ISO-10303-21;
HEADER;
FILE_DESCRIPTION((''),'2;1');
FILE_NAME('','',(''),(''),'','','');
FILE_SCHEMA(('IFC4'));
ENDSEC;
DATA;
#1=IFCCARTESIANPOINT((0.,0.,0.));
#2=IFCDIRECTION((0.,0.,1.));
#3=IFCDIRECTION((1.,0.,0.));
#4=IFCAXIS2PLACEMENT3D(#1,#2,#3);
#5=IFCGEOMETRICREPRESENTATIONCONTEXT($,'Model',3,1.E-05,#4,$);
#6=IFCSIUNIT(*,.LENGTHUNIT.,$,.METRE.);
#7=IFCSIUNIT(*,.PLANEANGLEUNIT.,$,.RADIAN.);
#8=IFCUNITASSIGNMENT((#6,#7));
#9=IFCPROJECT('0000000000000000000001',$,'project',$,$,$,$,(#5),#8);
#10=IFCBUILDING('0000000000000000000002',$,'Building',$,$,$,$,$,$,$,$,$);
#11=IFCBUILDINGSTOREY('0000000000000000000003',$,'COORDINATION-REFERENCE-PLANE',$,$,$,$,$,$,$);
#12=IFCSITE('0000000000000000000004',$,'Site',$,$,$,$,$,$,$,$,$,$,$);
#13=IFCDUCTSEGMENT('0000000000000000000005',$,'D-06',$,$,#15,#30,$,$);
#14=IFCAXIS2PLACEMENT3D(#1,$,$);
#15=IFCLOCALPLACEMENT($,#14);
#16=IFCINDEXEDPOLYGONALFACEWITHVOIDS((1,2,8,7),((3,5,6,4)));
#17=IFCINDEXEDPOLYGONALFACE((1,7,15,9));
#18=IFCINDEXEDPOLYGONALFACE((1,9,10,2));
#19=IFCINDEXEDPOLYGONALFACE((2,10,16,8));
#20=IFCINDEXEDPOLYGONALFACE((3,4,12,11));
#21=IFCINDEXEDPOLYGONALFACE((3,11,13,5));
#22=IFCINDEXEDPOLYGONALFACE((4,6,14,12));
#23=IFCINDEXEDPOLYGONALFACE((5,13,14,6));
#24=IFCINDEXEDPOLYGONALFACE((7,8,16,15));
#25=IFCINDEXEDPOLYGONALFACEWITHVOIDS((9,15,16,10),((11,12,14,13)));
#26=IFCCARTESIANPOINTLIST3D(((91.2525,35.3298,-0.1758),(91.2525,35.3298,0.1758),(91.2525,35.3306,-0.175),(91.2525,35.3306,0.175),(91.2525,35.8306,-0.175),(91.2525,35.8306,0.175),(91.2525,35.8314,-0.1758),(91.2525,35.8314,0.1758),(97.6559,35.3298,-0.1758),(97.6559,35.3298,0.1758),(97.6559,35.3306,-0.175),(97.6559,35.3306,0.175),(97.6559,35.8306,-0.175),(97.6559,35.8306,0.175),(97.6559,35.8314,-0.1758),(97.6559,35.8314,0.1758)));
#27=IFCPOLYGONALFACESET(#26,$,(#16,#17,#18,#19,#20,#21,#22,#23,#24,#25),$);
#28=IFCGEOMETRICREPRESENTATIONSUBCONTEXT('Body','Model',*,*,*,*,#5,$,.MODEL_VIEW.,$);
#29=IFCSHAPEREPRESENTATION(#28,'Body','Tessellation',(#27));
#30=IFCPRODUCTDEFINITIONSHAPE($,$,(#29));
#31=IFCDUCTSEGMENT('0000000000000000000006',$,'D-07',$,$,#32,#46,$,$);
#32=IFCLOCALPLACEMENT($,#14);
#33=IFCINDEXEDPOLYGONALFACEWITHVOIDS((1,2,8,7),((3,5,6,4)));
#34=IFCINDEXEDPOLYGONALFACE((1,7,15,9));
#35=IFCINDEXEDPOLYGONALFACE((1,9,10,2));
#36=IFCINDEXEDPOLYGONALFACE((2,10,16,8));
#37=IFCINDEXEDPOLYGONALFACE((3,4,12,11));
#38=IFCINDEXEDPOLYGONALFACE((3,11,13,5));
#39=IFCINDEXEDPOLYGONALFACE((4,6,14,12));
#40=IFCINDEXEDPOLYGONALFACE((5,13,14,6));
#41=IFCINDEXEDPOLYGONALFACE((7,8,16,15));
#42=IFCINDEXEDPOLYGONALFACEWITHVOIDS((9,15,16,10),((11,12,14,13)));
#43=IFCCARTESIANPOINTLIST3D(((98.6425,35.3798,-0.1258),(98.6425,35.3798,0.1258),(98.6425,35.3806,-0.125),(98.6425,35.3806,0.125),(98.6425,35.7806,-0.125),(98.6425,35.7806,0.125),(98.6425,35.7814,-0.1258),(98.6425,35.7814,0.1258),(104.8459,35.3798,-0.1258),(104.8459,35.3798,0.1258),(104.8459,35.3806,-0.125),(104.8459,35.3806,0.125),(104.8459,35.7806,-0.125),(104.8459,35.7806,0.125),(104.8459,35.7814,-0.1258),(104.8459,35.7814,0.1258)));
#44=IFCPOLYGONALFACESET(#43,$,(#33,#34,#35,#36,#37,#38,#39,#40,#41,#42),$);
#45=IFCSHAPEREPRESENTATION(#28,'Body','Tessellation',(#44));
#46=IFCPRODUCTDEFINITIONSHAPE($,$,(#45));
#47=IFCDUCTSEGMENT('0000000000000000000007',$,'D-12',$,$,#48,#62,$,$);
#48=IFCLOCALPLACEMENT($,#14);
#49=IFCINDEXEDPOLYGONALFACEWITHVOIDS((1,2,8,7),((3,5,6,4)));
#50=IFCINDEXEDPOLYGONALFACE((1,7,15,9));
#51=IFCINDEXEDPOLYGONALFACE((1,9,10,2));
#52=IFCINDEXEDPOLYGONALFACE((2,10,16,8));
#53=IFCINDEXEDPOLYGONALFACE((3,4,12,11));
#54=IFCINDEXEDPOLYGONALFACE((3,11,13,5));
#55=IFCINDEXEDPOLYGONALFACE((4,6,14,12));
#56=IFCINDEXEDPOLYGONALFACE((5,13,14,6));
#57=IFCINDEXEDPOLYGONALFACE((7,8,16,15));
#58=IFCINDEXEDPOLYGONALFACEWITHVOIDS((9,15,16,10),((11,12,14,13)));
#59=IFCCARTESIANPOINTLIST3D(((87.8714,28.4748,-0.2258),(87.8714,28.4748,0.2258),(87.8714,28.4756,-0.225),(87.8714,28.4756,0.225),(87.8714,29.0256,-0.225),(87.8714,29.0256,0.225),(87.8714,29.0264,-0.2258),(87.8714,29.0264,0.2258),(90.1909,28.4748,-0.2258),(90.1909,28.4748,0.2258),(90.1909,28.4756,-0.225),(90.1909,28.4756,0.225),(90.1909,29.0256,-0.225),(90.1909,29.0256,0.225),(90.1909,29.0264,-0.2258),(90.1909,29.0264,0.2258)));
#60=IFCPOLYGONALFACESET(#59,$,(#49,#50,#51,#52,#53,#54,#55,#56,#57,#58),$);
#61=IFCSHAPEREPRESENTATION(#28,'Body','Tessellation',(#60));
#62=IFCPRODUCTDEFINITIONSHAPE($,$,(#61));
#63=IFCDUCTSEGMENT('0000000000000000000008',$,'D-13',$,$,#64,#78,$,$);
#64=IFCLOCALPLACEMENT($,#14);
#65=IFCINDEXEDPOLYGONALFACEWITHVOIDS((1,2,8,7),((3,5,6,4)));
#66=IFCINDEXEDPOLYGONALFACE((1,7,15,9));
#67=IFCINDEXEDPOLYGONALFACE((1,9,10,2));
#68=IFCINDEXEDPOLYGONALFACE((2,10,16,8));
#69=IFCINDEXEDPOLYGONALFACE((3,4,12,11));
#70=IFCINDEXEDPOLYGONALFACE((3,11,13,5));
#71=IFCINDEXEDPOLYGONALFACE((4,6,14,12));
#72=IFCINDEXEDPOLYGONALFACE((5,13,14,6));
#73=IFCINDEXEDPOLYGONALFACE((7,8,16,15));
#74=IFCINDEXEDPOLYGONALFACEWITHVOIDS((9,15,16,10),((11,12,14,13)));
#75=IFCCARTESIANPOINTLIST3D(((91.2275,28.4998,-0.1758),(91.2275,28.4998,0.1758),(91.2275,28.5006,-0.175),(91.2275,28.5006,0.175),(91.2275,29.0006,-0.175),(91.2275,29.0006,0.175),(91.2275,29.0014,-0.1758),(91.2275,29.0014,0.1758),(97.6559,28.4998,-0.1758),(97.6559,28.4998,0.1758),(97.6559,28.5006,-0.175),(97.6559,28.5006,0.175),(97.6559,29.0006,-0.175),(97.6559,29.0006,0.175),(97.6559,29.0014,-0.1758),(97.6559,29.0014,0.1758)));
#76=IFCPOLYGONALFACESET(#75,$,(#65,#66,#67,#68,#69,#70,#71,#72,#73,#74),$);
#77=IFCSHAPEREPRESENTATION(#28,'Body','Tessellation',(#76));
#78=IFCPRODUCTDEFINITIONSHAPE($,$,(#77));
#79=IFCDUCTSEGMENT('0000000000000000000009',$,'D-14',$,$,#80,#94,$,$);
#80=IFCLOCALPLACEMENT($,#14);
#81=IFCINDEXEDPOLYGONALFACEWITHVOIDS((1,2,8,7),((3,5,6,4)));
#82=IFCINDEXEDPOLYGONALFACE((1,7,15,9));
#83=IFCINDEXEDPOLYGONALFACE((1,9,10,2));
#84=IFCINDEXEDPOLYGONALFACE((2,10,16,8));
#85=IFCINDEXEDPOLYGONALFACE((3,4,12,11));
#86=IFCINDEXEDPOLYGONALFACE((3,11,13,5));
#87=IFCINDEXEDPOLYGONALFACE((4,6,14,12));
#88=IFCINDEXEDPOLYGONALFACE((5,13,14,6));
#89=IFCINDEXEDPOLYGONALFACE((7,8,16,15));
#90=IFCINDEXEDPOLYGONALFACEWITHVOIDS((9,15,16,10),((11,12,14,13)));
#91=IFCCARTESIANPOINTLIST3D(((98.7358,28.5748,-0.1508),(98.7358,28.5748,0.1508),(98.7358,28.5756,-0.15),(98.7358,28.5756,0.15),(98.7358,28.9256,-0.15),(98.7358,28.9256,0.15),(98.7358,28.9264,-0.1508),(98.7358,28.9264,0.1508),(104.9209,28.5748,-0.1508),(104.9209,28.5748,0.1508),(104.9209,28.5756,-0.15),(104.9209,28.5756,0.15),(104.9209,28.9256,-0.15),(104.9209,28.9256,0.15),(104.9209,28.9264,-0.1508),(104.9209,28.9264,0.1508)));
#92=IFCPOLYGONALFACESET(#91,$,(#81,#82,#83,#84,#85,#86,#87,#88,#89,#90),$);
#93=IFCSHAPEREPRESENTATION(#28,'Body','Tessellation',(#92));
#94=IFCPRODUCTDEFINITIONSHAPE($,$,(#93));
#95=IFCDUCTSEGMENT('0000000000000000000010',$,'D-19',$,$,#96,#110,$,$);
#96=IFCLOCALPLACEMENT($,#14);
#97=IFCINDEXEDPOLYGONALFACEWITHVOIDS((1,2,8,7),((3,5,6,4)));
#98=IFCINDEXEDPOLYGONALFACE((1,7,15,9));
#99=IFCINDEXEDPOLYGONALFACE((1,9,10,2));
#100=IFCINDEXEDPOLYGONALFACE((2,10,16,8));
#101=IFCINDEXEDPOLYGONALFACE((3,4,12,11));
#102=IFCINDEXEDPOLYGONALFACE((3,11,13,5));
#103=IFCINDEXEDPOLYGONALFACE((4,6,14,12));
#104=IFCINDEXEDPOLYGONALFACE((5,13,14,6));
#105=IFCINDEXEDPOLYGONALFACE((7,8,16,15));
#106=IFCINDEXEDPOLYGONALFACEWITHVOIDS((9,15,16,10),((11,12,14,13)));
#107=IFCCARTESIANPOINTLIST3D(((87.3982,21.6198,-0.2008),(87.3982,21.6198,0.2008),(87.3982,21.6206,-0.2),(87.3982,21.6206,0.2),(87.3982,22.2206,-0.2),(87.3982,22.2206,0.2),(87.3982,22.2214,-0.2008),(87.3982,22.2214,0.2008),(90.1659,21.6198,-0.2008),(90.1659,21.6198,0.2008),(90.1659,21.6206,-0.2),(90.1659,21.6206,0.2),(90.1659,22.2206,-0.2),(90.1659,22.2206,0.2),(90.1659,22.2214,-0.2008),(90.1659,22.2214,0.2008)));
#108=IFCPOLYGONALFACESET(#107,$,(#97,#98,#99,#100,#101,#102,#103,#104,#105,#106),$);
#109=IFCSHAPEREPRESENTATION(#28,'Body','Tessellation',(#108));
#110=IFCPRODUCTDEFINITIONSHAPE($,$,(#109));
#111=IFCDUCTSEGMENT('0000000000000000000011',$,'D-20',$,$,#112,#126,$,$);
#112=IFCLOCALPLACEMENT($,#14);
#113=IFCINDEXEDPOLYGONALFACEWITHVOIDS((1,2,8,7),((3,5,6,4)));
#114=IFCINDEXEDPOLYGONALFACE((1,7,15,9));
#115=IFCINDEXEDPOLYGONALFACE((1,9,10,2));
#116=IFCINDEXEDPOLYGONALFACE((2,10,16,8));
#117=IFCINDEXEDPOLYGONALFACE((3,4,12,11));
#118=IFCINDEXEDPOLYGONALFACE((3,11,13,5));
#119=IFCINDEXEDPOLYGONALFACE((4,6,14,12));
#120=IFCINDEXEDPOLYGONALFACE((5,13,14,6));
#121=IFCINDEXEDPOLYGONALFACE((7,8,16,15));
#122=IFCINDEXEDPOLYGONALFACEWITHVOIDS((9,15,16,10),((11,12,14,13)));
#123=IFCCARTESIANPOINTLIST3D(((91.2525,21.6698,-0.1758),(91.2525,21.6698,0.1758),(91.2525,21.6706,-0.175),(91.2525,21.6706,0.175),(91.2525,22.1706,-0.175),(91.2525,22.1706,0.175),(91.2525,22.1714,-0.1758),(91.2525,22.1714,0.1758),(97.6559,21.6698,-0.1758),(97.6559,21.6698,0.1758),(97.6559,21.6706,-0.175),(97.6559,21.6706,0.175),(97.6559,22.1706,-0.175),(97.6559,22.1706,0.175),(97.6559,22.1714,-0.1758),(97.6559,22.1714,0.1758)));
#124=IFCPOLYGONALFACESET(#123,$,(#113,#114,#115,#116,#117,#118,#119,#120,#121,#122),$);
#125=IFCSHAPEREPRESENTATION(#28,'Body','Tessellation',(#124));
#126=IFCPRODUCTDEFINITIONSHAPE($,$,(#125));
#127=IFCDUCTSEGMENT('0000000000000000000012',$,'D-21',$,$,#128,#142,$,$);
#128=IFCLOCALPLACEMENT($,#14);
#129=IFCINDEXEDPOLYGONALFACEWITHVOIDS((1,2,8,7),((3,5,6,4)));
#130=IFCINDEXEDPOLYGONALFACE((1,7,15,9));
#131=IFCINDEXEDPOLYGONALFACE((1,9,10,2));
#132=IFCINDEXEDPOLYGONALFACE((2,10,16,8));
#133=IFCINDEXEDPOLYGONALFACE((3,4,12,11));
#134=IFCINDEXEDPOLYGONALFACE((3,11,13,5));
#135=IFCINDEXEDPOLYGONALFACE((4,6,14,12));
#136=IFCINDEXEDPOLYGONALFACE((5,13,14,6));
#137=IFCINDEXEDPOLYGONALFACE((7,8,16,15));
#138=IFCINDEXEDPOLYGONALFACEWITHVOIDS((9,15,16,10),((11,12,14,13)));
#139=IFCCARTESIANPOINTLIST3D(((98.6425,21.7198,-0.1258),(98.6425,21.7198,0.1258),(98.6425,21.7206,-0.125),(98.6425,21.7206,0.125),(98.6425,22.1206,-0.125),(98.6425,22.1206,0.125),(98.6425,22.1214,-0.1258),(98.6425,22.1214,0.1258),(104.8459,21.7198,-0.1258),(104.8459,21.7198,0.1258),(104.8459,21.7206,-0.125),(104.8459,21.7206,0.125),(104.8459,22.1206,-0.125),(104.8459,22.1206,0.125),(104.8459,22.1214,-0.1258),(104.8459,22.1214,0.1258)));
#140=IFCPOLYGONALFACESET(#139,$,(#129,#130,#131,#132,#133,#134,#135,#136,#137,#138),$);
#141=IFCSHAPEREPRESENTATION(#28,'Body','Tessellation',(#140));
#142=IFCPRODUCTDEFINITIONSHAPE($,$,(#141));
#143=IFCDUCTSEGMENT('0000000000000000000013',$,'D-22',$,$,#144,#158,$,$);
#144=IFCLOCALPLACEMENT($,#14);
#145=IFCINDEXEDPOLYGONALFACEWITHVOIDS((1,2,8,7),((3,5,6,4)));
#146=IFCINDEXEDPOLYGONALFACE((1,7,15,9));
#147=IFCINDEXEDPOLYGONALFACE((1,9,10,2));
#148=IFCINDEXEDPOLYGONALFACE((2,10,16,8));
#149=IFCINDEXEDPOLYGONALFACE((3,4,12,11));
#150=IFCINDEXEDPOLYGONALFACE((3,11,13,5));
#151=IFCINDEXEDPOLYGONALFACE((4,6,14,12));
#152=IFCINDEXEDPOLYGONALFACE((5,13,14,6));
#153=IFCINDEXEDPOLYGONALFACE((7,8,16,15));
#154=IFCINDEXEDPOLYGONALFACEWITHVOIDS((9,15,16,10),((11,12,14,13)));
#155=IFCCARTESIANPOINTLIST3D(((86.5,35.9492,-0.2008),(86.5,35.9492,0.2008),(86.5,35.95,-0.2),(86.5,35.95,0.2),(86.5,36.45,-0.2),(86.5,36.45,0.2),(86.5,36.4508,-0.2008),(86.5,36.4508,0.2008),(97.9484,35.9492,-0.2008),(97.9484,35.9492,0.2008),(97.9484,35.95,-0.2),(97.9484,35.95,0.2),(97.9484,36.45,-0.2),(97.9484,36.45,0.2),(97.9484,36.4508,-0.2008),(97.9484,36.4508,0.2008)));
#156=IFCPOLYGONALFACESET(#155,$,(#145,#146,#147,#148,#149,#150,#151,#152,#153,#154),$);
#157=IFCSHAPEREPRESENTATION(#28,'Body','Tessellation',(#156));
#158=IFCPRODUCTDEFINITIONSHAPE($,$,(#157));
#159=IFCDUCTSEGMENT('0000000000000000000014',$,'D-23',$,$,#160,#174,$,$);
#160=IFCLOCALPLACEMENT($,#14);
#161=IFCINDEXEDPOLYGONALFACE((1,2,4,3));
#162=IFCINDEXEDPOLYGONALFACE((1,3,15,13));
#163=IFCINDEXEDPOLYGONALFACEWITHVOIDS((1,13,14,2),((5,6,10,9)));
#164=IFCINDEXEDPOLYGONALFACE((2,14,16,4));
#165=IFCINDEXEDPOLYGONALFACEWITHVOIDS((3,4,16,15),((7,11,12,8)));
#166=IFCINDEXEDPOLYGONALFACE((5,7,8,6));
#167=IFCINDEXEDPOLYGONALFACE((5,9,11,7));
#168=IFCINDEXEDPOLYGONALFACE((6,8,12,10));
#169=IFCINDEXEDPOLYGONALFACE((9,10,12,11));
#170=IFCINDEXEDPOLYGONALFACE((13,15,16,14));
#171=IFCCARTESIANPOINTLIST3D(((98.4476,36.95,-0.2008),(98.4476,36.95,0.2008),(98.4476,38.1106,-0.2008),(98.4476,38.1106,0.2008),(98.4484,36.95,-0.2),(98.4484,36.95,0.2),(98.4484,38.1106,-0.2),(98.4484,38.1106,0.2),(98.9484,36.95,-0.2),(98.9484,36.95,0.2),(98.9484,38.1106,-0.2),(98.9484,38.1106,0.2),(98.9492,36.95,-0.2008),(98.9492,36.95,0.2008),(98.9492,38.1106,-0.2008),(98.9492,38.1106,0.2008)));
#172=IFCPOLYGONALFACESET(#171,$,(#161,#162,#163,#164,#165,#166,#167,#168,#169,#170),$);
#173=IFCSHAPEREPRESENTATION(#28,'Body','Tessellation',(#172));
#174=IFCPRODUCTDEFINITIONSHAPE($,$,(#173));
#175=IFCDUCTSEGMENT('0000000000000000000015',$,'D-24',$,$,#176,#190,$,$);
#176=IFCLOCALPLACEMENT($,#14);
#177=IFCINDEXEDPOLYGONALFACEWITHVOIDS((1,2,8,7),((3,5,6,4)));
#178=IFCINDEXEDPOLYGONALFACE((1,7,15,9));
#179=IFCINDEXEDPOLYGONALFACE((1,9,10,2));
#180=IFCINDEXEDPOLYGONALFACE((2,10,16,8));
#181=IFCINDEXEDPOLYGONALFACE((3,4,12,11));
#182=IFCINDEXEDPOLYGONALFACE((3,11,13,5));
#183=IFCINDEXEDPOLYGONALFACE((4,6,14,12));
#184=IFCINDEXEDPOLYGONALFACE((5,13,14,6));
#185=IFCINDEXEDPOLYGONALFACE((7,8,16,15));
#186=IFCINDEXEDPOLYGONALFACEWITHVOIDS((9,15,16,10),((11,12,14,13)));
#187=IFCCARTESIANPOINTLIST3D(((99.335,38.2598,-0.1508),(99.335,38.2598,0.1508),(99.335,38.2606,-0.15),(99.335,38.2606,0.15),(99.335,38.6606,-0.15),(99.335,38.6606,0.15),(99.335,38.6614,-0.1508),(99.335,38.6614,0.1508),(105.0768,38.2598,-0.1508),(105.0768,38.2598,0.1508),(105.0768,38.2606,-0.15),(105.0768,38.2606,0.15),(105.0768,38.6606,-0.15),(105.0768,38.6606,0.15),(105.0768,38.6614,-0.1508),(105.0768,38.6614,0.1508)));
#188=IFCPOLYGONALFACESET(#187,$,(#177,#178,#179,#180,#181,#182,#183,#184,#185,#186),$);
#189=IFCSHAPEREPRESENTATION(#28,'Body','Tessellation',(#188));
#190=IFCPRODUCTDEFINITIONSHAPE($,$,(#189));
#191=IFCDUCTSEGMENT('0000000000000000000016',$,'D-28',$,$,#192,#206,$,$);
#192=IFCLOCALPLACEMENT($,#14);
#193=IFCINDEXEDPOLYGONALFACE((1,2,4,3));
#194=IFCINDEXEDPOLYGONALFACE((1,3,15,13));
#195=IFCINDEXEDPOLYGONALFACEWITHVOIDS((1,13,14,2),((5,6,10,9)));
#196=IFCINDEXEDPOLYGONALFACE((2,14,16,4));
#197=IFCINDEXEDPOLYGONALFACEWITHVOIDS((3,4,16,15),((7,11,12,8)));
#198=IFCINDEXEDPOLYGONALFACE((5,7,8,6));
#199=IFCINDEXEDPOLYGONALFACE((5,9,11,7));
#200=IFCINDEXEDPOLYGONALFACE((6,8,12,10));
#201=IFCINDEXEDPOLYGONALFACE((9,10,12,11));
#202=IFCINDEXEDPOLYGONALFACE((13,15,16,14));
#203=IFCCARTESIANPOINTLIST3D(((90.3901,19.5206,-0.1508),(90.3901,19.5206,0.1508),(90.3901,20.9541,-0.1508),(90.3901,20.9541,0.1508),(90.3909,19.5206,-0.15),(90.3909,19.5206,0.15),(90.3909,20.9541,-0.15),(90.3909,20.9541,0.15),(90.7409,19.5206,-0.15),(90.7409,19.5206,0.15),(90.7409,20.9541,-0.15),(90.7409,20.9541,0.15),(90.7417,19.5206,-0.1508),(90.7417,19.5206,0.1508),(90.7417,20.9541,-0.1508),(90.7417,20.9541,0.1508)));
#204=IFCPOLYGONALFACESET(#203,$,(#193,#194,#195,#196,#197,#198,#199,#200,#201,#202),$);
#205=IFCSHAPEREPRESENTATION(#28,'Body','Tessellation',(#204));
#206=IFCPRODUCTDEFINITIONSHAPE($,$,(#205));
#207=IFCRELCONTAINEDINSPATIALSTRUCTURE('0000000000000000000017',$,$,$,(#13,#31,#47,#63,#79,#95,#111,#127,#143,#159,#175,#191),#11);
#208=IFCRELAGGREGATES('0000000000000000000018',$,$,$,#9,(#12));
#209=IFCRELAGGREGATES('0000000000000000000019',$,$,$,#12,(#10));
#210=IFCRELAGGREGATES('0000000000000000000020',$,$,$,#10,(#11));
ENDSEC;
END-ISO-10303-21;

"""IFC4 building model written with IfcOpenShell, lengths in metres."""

from ifc_helpers import new_model, si_unit, frame, origin, origin_with_axes, place, context, subcontext, project, spatial, hollow_rectangle, extrude, element, save


model = new_model("IFC4")

# Units and contexts
model_context = context("Model", 3, precision=1e-05, world=origin_with_axes())
body_context = subcontext(model_context, "Body", "Model", "MODEL_VIEW")
ifc_project = project(units=[si_unit("LENGTHUNIT", "METRE"), si_unit("PLANEANGLEUNIT", "RADIAN")], contexts=[model_context])

# Site, building, storey
site = spatial("IfcSite", under=ifc_project, Name="Site")
building = spatial("IfcBuilding", under=site, Name="Building")
storey = spatial("IfcBuildingStorey", under=building, Name="COORDINATION-REFERENCE-PLANE")

# Duct segments
duct_segment_1_placement = place(None, frame((91.2525, 35.5806, 0.0), z_axis=(1.0, 0.0, 0.0), x_axis=(0.0, 1.0, 0.0)))
element("IfcDuctSegment", 1, at=duct_segment_1_placement, inside=storey, Name="D-06", context=body_context, shape_type="SweptSolid", body=[
    extrude(hollow_rectangle(XDim=0.5016, YDim=0.3516, WallThickness=0.0008), origin(), (0.0, 0.0, 1.0), 6.4034),
])
duct_segment_2_placement = place(None, frame((98.6425, 35.5806, 0.0), z_axis=(1.0, 0.0, 0.0), x_axis=(0.0, 1.0, 0.0)))
element("IfcDuctSegment", 2, at=duct_segment_2_placement, inside=storey, Name="D-07", context=body_context, shape_type="SweptSolid", body=[
    extrude(hollow_rectangle(XDim=0.4016, YDim=0.2516, WallThickness=0.0008), origin(), (0.0, 0.0, 1.0), 6.2034),
])
duct_segment_3_placement = place(None, frame((87.8714, 28.7506, 0.0), z_axis=(1.0, 0.0, 0.0), x_axis=(0.0, 1.0, 0.0)))
element("IfcDuctSegment", 3, at=duct_segment_3_placement, inside=storey, Name="D-12", context=body_context, shape_type="SweptSolid", body=[
    extrude(hollow_rectangle(XDim=0.5516, YDim=0.4516, WallThickness=0.0008), origin(), (0.0, 0.0, 1.0), 2.3195),
])
duct_segment_4_placement = place(None, frame((91.2275, 28.7506, 0.0), z_axis=(1.0, 0.0, 0.0), x_axis=(0.0, 1.0, 0.0)))
element("IfcDuctSegment", 4, at=duct_segment_4_placement, inside=storey, Name="D-13", context=body_context, shape_type="SweptSolid", body=[
    extrude(hollow_rectangle(XDim=0.5016, YDim=0.3516, WallThickness=0.0008), origin(), (0.0, 0.0, 1.0), 6.4284),
])
duct_segment_5_placement = place(None, frame((98.7358, 28.7506, 0.0), z_axis=(1.0, 0.0, 0.0), x_axis=(0.0, 1.0, 0.0)))
element("IfcDuctSegment", 5, at=duct_segment_5_placement, inside=storey, Name="D-14", context=body_context, shape_type="SweptSolid", body=[
    extrude(hollow_rectangle(XDim=0.3516, YDim=0.3016, WallThickness=0.0008), origin(), (0.0, 0.0, 1.0), 6.1851),
])
duct_segment_6_placement = place(None, frame((87.3982, 21.9206, 0.0), z_axis=(1.0, 0.0, 0.0), x_axis=(0.0, 1.0, 0.0)))
element("IfcDuctSegment", 6, at=duct_segment_6_placement, inside=storey, Name="D-19", context=body_context, shape_type="SweptSolid", body=[
    extrude(hollow_rectangle(XDim=0.6016, YDim=0.4016, WallThickness=0.0008), origin(), (0.0, 0.0, 1.0), 2.7677),
])
duct_segment_7_placement = place(None, frame((91.2525, 21.9206, 0.0), z_axis=(1.0, 0.0, 0.0), x_axis=(0.0, 1.0, 0.0)))
element("IfcDuctSegment", 7, at=duct_segment_7_placement, inside=storey, Name="D-20", context=body_context, shape_type="SweptSolid", body=[
    extrude(hollow_rectangle(XDim=0.5016, YDim=0.3516, WallThickness=0.0008), origin(), (0.0, 0.0, 1.0), 6.4034),
])
duct_segment_8_placement = place(None, frame((98.6425, 21.9206, 0.0), z_axis=(1.0, 0.0, 0.0), x_axis=(0.0, 1.0, 0.0)))
element("IfcDuctSegment", 8, at=duct_segment_8_placement, inside=storey, Name="D-21", context=body_context, shape_type="SweptSolid", body=[
    extrude(hollow_rectangle(XDim=0.4016, YDim=0.2516, WallThickness=0.0008), origin(), (0.0, 0.0, 1.0), 6.2034),
])
duct_segment_9_placement = place(None, frame((86.5, 36.2, 0.0), z_axis=(1.0, 0.0, 0.0), x_axis=(0.0, 1.0, 0.0)))
element("IfcDuctSegment", 9, at=duct_segment_9_placement, inside=storey, Name="D-22", context=body_context, shape_type="SweptSolid", body=[
    extrude(hollow_rectangle(XDim=0.5016, YDim=0.4016, WallThickness=0.0008), origin(), (0.0, 0.0, 1.0), 11.4484),
])
duct_segment_10_placement = place(None, frame((98.6984, 36.95, 0.0), z_axis=(0.0, 1.0, 0.0), x_axis=(1.0, 0.0, 0.0)))
element("IfcDuctSegment", 10, at=duct_segment_10_placement, inside=storey, Name="D-23", context=body_context, shape_type="SweptSolid", body=[
    extrude(hollow_rectangle(XDim=0.5016, YDim=0.4016, WallThickness=0.0008), origin(), (0.0, 0.0, 1.0), 1.1606),
])
duct_segment_11_placement = place(None, frame((99.335, 38.4606, 0.0), z_axis=(1.0, 0.0, 0.0), x_axis=(0.0, 1.0, 0.0)))
element("IfcDuctSegment", 11, at=duct_segment_11_placement, inside=storey, Name="D-24", context=body_context, shape_type="SweptSolid", body=[
    extrude(hollow_rectangle(XDim=0.4016, YDim=0.3016, WallThickness=0.0008), origin(), (0.0, 0.0, 1.0), 5.7417),
])
duct_segment_12_placement = place(None, frame((90.5659, 19.5206, 0.0), z_axis=(0.0, 1.0, 0.0), x_axis=(1.0, 0.0, 0.0)))
element("IfcDuctSegment", 12, at=duct_segment_12_placement, inside=storey, Name="D-28", context=body_context, shape_type="SweptSolid", body=[
    extrude(hollow_rectangle(XDim=0.3516, YDim=0.3016, WallThickness=0.0008), origin(), (0.0, 0.0, 1.0), 1.4335),
])

save(model, "model.ifc")
